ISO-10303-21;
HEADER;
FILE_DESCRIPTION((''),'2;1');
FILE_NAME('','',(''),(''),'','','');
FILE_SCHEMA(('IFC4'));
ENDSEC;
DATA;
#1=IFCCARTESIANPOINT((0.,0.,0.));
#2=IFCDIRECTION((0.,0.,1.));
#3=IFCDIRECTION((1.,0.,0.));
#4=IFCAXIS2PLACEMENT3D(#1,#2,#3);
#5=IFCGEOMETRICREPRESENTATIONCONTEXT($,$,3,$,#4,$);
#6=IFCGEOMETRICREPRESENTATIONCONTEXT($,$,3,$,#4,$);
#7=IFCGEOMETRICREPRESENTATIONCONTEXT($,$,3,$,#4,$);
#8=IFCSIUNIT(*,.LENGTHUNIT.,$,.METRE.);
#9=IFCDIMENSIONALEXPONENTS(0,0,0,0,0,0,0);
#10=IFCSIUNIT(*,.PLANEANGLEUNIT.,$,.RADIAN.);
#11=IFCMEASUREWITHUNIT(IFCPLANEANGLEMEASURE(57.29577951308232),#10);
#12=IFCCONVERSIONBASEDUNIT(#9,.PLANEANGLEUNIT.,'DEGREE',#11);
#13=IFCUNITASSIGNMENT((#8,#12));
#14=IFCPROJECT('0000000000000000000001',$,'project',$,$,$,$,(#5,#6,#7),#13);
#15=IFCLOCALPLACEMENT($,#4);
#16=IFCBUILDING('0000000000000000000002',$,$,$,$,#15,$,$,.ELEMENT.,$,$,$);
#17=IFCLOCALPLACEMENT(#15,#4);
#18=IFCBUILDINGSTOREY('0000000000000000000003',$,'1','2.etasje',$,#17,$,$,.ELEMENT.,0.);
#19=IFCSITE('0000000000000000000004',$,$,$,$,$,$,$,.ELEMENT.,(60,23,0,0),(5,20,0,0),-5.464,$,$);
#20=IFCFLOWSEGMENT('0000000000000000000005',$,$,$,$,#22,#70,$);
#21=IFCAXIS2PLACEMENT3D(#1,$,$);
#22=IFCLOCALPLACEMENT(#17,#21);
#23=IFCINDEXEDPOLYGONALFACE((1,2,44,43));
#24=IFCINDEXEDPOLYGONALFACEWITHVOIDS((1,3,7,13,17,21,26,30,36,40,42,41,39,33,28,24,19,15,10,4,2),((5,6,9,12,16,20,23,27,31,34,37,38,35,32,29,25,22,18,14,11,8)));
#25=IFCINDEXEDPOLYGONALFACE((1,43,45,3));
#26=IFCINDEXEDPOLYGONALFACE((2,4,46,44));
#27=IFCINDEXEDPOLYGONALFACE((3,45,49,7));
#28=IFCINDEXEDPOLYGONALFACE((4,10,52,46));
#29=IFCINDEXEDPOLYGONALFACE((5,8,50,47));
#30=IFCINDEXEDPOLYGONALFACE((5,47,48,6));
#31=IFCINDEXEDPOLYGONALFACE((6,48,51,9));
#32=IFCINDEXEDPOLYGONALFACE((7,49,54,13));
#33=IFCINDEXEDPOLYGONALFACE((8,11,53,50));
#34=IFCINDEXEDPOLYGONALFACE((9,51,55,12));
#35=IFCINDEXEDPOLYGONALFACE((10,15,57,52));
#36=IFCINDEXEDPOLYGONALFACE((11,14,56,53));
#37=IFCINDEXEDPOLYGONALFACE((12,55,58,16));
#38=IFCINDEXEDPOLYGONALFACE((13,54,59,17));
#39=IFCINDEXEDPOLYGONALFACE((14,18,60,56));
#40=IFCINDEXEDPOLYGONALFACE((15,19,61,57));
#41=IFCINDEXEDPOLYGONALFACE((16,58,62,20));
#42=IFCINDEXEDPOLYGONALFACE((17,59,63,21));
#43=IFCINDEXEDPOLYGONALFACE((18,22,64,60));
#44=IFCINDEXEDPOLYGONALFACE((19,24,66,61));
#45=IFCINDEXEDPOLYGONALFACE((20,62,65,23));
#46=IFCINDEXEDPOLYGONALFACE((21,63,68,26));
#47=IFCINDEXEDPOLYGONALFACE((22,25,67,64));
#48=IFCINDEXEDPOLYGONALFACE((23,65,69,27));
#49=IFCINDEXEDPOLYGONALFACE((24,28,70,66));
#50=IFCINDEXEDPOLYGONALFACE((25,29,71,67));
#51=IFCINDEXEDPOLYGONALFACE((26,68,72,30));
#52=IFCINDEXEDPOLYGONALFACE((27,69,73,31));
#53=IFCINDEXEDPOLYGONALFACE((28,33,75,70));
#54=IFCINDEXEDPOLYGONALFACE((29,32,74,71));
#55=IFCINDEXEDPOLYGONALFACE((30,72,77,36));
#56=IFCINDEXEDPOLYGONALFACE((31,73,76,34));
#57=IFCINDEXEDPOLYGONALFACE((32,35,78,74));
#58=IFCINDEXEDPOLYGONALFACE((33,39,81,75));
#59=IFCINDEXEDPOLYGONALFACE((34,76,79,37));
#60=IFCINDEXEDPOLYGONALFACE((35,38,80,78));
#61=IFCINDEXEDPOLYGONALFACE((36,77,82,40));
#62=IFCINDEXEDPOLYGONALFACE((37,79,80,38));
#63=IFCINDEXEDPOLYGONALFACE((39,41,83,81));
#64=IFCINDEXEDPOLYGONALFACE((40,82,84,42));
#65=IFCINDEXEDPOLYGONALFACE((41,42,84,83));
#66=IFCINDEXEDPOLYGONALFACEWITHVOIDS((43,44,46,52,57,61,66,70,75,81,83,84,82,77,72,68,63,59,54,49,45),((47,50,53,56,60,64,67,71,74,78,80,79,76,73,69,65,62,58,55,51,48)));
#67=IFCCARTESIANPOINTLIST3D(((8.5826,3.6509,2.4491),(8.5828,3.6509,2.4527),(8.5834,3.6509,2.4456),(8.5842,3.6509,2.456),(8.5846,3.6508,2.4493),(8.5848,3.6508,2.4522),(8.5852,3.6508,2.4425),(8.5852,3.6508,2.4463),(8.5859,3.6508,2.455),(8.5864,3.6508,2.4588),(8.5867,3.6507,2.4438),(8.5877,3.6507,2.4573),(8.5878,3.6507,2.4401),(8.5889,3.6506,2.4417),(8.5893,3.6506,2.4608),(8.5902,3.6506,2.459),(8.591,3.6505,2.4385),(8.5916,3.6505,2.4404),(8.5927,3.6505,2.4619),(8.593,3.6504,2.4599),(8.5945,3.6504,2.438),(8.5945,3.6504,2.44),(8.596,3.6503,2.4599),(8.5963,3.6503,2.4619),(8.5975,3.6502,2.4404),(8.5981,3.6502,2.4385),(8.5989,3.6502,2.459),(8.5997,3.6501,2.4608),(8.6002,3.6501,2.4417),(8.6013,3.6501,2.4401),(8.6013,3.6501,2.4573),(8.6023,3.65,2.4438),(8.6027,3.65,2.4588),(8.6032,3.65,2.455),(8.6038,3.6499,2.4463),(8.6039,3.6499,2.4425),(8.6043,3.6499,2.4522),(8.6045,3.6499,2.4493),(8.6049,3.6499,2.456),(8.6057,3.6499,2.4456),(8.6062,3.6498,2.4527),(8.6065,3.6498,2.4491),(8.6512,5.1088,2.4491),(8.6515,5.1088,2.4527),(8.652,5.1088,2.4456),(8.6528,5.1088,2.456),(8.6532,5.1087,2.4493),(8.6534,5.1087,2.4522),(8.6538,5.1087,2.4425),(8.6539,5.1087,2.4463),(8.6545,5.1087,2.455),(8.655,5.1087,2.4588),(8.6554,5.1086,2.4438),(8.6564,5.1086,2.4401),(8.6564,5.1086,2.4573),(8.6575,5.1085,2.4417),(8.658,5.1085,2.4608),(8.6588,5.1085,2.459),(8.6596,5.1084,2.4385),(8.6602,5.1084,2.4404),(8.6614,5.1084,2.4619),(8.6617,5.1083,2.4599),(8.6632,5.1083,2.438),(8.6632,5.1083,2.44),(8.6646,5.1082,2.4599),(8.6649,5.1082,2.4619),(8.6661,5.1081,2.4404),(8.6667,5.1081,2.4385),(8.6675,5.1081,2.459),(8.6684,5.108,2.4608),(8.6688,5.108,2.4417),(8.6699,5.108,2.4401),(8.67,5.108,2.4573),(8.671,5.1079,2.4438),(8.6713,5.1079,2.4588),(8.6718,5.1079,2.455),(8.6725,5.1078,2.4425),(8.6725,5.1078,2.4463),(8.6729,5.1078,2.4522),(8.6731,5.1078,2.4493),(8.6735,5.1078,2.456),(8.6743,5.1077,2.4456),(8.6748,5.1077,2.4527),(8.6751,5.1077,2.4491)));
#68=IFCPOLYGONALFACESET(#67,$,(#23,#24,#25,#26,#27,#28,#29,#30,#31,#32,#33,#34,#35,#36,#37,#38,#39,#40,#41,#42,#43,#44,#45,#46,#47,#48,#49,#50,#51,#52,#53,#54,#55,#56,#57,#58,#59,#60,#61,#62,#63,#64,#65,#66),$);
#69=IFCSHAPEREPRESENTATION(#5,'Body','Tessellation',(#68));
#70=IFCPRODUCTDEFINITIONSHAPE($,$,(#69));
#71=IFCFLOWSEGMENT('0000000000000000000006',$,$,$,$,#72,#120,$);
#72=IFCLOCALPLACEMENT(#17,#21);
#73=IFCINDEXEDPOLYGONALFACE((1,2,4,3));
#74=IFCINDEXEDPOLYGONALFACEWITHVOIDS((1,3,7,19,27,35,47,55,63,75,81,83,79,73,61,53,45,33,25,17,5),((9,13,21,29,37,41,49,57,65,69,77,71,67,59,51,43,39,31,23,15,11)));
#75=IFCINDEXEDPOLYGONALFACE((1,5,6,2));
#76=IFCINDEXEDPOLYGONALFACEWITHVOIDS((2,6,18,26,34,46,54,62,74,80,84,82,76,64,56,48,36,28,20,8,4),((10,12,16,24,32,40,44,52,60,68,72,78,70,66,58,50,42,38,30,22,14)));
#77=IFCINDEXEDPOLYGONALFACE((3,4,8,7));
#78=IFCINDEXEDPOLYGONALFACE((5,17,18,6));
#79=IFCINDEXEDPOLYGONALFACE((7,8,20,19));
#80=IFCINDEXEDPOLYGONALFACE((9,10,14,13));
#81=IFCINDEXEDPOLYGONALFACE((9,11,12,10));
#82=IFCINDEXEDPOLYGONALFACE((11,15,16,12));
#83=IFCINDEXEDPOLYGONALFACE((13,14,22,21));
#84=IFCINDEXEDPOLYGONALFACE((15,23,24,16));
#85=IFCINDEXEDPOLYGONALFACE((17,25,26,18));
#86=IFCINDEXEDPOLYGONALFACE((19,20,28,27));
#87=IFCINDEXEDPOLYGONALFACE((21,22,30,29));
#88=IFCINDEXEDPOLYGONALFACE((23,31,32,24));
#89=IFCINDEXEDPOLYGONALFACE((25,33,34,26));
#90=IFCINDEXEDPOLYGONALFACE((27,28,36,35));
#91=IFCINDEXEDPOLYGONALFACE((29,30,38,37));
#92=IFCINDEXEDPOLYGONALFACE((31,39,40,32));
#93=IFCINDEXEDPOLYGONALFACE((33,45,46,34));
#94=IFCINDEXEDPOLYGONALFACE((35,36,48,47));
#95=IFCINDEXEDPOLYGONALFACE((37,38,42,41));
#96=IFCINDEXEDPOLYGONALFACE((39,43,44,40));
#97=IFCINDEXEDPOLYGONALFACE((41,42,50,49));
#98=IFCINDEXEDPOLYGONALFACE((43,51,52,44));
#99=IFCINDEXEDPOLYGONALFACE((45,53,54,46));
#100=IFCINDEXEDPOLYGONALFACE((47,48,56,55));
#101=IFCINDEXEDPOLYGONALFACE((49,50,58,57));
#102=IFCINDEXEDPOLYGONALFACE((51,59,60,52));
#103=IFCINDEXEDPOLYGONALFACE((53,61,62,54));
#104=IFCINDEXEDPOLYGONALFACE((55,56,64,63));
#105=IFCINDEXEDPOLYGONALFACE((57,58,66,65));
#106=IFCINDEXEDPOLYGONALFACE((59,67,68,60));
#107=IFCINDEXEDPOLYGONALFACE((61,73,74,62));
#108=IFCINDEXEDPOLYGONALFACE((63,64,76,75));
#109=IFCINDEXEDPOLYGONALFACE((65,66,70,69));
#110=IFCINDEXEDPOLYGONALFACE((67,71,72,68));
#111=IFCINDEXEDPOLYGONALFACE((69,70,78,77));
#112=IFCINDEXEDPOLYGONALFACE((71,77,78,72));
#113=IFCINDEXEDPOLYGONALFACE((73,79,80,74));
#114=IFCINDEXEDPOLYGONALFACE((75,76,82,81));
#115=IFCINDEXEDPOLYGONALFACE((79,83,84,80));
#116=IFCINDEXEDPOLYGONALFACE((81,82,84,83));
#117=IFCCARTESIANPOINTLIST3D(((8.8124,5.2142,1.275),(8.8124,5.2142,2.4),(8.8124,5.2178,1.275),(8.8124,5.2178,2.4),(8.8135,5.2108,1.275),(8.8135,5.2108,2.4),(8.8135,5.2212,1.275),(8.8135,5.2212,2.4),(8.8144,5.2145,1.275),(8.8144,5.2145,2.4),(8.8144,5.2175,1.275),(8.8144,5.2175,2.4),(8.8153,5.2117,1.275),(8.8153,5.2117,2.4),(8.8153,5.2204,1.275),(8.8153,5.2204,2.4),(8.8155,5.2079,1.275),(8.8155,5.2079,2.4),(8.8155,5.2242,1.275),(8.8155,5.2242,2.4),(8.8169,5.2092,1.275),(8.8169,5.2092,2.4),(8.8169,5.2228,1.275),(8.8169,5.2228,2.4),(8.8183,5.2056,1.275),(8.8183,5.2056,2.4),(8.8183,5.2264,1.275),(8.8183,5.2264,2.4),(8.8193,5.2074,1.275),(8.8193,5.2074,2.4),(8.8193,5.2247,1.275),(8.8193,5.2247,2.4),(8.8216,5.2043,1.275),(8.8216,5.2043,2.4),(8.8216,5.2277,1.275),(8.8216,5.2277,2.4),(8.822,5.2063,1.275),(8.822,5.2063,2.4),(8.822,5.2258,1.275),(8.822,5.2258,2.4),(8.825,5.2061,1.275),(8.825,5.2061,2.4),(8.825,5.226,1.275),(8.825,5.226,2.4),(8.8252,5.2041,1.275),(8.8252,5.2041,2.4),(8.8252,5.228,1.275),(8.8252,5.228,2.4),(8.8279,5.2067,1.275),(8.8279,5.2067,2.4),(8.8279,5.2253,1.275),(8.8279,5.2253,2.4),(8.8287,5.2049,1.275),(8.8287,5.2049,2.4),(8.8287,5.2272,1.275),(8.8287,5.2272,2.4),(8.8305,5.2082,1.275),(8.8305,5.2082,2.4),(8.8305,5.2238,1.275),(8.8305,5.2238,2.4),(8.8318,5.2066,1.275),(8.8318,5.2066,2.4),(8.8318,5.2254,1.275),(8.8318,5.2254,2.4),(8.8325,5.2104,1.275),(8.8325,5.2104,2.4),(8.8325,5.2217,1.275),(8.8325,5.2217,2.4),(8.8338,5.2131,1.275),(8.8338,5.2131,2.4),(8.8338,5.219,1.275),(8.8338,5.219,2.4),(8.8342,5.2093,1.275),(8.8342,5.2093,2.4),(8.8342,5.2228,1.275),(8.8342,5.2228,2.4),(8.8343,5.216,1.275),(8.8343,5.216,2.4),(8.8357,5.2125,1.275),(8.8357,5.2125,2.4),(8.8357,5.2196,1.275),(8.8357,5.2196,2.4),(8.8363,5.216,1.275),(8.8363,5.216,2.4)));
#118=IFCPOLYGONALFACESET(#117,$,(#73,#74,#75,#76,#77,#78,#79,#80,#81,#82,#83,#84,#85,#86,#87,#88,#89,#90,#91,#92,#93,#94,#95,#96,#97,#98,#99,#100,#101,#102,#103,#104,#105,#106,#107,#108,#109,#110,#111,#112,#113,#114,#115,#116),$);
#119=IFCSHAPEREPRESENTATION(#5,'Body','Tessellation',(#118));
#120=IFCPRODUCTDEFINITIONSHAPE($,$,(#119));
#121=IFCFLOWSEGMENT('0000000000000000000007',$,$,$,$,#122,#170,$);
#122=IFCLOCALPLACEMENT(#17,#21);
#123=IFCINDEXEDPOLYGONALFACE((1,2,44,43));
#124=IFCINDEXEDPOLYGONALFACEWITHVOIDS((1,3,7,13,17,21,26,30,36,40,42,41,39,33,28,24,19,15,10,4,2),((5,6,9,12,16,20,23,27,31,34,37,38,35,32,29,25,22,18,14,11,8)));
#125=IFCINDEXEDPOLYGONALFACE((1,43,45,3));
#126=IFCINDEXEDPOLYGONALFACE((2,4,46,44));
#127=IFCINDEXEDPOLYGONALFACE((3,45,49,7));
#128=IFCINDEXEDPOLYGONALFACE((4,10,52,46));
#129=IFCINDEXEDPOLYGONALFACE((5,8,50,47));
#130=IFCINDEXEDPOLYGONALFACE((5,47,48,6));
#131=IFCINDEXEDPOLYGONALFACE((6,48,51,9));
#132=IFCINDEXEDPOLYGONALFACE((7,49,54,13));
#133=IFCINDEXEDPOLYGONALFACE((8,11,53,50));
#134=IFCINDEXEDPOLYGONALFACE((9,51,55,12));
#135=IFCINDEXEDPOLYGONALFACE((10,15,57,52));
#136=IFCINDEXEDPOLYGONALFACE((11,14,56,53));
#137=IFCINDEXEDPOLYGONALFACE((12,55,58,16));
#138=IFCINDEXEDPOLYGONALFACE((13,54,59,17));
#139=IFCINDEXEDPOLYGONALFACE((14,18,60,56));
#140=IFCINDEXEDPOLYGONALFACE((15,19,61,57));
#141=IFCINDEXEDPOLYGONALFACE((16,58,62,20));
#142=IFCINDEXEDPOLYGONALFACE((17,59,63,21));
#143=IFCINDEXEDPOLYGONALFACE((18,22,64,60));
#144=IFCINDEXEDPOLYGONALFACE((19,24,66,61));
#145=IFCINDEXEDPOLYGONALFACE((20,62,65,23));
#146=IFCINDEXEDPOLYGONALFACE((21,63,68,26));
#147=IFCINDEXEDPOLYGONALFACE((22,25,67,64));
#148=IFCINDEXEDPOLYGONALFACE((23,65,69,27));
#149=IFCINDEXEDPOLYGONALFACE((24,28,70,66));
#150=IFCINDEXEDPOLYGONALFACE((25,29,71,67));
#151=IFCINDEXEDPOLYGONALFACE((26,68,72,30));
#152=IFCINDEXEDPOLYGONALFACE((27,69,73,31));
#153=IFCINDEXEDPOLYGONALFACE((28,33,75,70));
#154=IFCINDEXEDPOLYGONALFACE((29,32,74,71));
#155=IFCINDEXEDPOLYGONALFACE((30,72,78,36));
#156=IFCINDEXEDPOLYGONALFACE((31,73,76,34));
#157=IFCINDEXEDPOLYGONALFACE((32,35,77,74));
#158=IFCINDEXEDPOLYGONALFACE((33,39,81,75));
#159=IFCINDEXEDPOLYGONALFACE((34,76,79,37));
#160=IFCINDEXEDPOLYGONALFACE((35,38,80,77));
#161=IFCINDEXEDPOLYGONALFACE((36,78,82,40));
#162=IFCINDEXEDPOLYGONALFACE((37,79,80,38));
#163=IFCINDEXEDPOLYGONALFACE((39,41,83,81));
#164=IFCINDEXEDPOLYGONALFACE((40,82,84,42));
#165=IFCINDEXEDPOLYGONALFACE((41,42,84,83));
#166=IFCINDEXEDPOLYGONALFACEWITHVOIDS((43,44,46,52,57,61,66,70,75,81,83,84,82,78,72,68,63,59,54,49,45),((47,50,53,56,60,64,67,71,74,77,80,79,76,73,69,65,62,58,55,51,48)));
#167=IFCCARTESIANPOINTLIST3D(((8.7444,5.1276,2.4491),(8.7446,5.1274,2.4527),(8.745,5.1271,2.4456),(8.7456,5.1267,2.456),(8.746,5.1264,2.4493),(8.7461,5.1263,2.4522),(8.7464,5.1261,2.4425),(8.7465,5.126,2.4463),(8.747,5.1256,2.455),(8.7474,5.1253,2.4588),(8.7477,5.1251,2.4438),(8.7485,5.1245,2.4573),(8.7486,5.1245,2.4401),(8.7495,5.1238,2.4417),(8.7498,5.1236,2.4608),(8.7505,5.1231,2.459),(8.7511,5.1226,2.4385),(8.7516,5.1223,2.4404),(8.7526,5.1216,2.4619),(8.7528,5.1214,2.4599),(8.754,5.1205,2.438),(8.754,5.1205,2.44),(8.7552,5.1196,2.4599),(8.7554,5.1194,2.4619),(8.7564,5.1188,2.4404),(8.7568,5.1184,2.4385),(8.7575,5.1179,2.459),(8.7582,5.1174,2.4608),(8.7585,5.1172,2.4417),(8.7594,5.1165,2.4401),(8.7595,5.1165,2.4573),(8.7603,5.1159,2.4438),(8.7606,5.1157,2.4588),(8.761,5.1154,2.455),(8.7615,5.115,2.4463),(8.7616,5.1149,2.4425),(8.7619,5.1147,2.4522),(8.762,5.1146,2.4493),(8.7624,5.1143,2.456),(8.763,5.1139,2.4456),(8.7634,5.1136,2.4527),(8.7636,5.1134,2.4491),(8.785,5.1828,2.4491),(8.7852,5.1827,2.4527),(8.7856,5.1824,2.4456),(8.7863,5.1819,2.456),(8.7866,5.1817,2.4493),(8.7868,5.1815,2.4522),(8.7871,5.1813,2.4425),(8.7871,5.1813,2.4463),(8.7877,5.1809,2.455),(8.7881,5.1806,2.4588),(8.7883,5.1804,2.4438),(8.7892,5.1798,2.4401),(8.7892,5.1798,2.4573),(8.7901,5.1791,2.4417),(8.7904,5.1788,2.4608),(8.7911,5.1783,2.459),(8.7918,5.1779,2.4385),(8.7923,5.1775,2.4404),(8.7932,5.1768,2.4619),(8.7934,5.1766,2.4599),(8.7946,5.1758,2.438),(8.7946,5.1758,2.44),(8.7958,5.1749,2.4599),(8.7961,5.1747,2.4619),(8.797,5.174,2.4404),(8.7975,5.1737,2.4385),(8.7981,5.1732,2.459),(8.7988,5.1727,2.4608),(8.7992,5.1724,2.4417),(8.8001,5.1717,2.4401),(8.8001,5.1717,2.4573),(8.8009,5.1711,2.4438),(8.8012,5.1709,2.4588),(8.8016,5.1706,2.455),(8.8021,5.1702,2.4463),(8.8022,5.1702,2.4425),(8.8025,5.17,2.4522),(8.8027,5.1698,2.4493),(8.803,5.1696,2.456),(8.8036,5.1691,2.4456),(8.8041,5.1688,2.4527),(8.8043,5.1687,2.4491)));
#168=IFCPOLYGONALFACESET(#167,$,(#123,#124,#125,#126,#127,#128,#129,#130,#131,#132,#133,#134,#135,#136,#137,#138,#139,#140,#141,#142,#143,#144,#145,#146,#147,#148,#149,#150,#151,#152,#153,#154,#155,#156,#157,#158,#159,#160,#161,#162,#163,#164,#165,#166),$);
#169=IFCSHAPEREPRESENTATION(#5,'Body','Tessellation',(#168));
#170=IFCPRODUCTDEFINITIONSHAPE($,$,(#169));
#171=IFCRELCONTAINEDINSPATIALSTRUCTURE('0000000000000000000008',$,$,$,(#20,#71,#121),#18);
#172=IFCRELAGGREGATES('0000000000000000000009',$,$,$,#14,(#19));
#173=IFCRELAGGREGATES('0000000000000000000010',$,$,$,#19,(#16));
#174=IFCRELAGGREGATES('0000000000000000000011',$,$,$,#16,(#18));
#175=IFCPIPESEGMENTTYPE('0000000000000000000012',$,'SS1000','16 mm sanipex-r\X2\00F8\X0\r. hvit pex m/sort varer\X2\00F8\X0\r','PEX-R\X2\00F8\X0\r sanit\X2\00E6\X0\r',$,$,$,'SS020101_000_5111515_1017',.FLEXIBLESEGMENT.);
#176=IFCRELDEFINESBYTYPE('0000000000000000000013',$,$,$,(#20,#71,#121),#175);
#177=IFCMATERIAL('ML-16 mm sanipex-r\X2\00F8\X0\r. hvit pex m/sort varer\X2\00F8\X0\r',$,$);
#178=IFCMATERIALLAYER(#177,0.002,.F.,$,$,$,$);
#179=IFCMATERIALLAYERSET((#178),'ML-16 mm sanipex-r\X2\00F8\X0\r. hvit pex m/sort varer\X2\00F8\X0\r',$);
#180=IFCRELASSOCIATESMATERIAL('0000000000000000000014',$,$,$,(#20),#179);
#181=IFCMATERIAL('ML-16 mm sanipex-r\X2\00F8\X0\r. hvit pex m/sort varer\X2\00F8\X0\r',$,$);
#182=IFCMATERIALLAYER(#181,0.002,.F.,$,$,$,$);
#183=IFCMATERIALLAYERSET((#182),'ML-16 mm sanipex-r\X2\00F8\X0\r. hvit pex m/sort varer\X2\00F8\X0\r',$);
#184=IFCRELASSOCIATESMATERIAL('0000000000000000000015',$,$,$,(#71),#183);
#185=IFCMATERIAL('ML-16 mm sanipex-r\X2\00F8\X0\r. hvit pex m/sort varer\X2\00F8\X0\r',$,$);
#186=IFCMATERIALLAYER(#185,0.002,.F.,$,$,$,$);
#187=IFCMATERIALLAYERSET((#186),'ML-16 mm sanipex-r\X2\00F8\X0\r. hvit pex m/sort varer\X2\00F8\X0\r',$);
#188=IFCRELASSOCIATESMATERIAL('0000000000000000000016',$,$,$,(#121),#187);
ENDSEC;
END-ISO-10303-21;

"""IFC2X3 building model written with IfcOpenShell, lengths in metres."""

from ifc_helpers import new_model, entity, si_unit, converted_unit, frame, origin_with_axes, origin_2d_with_axis, place, context, project, spatial, hollow_circle, extrude, material, layer, layer_set, layer_usage, type_object, element, save


model = new_model("IFC2X3")

# Units and contexts
context_of_model_1 = context(None, 3, world=origin_with_axes())
context_of_model_2 = context(None, 3, world=origin_with_axes())
context_of_model_3 = context(None, 3, world=origin_with_axes())
ifc_project = project(units=[si_unit("LENGTHUNIT", "METRE"), converted_unit("PLANEANGLEUNIT", "DEGREE", entity("IfcPlaneAngleMeasure", 57.29577951308232), si_unit("PLANEANGLEUNIT", "RADIAN"), dimensions=[0, 0, 0, 0, 0, 0, 0])], contexts=[context_of_model_1, context_of_model_2, context_of_model_3])

# Site, building, storey
site = spatial("IfcSite", under=ifc_project, CompositionType="ELEMENT", RefLatitude=(60, 23, 0, 0), RefLongitude=(5, 20, 0, 0), RefElevation=-5.464)
building_placement = place(None, origin_with_axes())
building = spatial("IfcBuilding", under=site, at=building_placement, CompositionType="ELEMENT")
storey_placement = place(building_placement, origin_with_axes())
storey = spatial("IfcBuildingStorey", under=building, at=storey_placement, Name="1", Description="2.etasje", CompositionType="ELEMENT", Elevation=0.0)

# Flow segments
pipe_segment_type_1 = type_object("IfcPipeSegmentType", Name="SS1000", Description="16 mm sanipex-rør. hvit pex m/sort varerør", ApplicableOccurrence="PEX-Rør sanitær", ElementType="SS020101_000_5111515_1017", PredefinedType="FLEXIBLESEGMENT")
ifc_material_1 = material(Name="ML-16 mm sanipex-rør. hvit pex m/sort varerør")
ifc_layer_1 = layer(ifc_material_1, 0.002, ventilated=False)
ifc_layer_set_1 = layer_set([ifc_layer_1], Name="ML-16 mm sanipex-rør. hvit pex m/sort varerør")
ifc_layer_usage_1 = layer_usage(ifc_layer_set_1, "AXIS2", "POSITIVE", 0.0)
flow_segment_1_placement = place(storey_placement, frame((8.6632, 5.1083, 2.45), z_axis=(-0.047021, -0.998894, 0.0), x_axis=(0.0, 0.0, -1.0)))
element("IfcFlowSegment", 1, at=flow_segment_1_placement, inside=storey, type_object=pipe_segment_type_1, material=ifc_layer_usage_1, context=context_of_model_1, shape_type="SweptSolid", body=[
    extrude(hollow_circle(Radius=0.012, WallThickness=0.002, at=origin_2d_with_axis()), origin_with_axes(), (0.0, 0.0, 1.0), 1.4595),
])
ifc_material_2 = material(Name="ML-16 mm sanipex-rør. hvit pex m/sort varerør")
ifc_layer_2 = layer(ifc_material_2, 0.002, ventilated=False)
ifc_layer_set_2 = layer_set([ifc_layer_2], Name="ML-16 mm sanipex-rør. hvit pex m/sort varerør")
ifc_layer_usage_2 = layer_usage(ifc_layer_set_2, "AXIS2", "POSITIVE", 0.0)
flow_segment_2_placement = place(storey_placement, frame((8.8243, 5.216, 1.275), z_axis=(0.0, 0.0, 1.0), x_axis=(1.0, 0.0, 0.0)))
element("IfcFlowSegment", 2, at=flow_segment_2_placement, inside=storey, type_object=pipe_segment_type_1, material=ifc_layer_usage_2, context=context_of_model_1, shape_type="SweptSolid", body=[
    extrude(hollow_circle(Radius=0.012, WallThickness=0.002, at=origin_2d_with_axis()), origin_with_axes(), (0.0, 0.0, 1.0), 1.125),
])
ifc_material_3 = material(Name="ML-16 mm sanipex-rør. hvit pex m/sort varerør")
ifc_layer_3 = layer(ifc_material_3, 0.002, ventilated=False)
ifc_layer_set_3 = layer_set([ifc_layer_3], Name="ML-16 mm sanipex-rør. hvit pex m/sort varerør")
ifc_layer_usage_3 = layer_usage(ifc_layer_set_3, "AXIS2", "POSITIVE", 0.0)
flow_segment_3_placement = place(storey_placement, frame((8.7946, 5.1758, 2.45), z_axis=(-0.59258, -0.805512, 0.0), x_axis=(0.0, 0.0, -1.0)))
element("IfcFlowSegment", 3, at=flow_segment_3_placement, inside=storey, type_object=pipe_segment_type_1, material=ifc_layer_usage_3, context=context_of_model_1, shape_type="SweptSolid", body=[
    extrude(hollow_circle(Radius=0.012, WallThickness=0.002, at=origin_2d_with_axis()), origin_with_axes(), (0.0, 0.0, 1.0), 0.0686),
])

save(model, "model.ifc")
